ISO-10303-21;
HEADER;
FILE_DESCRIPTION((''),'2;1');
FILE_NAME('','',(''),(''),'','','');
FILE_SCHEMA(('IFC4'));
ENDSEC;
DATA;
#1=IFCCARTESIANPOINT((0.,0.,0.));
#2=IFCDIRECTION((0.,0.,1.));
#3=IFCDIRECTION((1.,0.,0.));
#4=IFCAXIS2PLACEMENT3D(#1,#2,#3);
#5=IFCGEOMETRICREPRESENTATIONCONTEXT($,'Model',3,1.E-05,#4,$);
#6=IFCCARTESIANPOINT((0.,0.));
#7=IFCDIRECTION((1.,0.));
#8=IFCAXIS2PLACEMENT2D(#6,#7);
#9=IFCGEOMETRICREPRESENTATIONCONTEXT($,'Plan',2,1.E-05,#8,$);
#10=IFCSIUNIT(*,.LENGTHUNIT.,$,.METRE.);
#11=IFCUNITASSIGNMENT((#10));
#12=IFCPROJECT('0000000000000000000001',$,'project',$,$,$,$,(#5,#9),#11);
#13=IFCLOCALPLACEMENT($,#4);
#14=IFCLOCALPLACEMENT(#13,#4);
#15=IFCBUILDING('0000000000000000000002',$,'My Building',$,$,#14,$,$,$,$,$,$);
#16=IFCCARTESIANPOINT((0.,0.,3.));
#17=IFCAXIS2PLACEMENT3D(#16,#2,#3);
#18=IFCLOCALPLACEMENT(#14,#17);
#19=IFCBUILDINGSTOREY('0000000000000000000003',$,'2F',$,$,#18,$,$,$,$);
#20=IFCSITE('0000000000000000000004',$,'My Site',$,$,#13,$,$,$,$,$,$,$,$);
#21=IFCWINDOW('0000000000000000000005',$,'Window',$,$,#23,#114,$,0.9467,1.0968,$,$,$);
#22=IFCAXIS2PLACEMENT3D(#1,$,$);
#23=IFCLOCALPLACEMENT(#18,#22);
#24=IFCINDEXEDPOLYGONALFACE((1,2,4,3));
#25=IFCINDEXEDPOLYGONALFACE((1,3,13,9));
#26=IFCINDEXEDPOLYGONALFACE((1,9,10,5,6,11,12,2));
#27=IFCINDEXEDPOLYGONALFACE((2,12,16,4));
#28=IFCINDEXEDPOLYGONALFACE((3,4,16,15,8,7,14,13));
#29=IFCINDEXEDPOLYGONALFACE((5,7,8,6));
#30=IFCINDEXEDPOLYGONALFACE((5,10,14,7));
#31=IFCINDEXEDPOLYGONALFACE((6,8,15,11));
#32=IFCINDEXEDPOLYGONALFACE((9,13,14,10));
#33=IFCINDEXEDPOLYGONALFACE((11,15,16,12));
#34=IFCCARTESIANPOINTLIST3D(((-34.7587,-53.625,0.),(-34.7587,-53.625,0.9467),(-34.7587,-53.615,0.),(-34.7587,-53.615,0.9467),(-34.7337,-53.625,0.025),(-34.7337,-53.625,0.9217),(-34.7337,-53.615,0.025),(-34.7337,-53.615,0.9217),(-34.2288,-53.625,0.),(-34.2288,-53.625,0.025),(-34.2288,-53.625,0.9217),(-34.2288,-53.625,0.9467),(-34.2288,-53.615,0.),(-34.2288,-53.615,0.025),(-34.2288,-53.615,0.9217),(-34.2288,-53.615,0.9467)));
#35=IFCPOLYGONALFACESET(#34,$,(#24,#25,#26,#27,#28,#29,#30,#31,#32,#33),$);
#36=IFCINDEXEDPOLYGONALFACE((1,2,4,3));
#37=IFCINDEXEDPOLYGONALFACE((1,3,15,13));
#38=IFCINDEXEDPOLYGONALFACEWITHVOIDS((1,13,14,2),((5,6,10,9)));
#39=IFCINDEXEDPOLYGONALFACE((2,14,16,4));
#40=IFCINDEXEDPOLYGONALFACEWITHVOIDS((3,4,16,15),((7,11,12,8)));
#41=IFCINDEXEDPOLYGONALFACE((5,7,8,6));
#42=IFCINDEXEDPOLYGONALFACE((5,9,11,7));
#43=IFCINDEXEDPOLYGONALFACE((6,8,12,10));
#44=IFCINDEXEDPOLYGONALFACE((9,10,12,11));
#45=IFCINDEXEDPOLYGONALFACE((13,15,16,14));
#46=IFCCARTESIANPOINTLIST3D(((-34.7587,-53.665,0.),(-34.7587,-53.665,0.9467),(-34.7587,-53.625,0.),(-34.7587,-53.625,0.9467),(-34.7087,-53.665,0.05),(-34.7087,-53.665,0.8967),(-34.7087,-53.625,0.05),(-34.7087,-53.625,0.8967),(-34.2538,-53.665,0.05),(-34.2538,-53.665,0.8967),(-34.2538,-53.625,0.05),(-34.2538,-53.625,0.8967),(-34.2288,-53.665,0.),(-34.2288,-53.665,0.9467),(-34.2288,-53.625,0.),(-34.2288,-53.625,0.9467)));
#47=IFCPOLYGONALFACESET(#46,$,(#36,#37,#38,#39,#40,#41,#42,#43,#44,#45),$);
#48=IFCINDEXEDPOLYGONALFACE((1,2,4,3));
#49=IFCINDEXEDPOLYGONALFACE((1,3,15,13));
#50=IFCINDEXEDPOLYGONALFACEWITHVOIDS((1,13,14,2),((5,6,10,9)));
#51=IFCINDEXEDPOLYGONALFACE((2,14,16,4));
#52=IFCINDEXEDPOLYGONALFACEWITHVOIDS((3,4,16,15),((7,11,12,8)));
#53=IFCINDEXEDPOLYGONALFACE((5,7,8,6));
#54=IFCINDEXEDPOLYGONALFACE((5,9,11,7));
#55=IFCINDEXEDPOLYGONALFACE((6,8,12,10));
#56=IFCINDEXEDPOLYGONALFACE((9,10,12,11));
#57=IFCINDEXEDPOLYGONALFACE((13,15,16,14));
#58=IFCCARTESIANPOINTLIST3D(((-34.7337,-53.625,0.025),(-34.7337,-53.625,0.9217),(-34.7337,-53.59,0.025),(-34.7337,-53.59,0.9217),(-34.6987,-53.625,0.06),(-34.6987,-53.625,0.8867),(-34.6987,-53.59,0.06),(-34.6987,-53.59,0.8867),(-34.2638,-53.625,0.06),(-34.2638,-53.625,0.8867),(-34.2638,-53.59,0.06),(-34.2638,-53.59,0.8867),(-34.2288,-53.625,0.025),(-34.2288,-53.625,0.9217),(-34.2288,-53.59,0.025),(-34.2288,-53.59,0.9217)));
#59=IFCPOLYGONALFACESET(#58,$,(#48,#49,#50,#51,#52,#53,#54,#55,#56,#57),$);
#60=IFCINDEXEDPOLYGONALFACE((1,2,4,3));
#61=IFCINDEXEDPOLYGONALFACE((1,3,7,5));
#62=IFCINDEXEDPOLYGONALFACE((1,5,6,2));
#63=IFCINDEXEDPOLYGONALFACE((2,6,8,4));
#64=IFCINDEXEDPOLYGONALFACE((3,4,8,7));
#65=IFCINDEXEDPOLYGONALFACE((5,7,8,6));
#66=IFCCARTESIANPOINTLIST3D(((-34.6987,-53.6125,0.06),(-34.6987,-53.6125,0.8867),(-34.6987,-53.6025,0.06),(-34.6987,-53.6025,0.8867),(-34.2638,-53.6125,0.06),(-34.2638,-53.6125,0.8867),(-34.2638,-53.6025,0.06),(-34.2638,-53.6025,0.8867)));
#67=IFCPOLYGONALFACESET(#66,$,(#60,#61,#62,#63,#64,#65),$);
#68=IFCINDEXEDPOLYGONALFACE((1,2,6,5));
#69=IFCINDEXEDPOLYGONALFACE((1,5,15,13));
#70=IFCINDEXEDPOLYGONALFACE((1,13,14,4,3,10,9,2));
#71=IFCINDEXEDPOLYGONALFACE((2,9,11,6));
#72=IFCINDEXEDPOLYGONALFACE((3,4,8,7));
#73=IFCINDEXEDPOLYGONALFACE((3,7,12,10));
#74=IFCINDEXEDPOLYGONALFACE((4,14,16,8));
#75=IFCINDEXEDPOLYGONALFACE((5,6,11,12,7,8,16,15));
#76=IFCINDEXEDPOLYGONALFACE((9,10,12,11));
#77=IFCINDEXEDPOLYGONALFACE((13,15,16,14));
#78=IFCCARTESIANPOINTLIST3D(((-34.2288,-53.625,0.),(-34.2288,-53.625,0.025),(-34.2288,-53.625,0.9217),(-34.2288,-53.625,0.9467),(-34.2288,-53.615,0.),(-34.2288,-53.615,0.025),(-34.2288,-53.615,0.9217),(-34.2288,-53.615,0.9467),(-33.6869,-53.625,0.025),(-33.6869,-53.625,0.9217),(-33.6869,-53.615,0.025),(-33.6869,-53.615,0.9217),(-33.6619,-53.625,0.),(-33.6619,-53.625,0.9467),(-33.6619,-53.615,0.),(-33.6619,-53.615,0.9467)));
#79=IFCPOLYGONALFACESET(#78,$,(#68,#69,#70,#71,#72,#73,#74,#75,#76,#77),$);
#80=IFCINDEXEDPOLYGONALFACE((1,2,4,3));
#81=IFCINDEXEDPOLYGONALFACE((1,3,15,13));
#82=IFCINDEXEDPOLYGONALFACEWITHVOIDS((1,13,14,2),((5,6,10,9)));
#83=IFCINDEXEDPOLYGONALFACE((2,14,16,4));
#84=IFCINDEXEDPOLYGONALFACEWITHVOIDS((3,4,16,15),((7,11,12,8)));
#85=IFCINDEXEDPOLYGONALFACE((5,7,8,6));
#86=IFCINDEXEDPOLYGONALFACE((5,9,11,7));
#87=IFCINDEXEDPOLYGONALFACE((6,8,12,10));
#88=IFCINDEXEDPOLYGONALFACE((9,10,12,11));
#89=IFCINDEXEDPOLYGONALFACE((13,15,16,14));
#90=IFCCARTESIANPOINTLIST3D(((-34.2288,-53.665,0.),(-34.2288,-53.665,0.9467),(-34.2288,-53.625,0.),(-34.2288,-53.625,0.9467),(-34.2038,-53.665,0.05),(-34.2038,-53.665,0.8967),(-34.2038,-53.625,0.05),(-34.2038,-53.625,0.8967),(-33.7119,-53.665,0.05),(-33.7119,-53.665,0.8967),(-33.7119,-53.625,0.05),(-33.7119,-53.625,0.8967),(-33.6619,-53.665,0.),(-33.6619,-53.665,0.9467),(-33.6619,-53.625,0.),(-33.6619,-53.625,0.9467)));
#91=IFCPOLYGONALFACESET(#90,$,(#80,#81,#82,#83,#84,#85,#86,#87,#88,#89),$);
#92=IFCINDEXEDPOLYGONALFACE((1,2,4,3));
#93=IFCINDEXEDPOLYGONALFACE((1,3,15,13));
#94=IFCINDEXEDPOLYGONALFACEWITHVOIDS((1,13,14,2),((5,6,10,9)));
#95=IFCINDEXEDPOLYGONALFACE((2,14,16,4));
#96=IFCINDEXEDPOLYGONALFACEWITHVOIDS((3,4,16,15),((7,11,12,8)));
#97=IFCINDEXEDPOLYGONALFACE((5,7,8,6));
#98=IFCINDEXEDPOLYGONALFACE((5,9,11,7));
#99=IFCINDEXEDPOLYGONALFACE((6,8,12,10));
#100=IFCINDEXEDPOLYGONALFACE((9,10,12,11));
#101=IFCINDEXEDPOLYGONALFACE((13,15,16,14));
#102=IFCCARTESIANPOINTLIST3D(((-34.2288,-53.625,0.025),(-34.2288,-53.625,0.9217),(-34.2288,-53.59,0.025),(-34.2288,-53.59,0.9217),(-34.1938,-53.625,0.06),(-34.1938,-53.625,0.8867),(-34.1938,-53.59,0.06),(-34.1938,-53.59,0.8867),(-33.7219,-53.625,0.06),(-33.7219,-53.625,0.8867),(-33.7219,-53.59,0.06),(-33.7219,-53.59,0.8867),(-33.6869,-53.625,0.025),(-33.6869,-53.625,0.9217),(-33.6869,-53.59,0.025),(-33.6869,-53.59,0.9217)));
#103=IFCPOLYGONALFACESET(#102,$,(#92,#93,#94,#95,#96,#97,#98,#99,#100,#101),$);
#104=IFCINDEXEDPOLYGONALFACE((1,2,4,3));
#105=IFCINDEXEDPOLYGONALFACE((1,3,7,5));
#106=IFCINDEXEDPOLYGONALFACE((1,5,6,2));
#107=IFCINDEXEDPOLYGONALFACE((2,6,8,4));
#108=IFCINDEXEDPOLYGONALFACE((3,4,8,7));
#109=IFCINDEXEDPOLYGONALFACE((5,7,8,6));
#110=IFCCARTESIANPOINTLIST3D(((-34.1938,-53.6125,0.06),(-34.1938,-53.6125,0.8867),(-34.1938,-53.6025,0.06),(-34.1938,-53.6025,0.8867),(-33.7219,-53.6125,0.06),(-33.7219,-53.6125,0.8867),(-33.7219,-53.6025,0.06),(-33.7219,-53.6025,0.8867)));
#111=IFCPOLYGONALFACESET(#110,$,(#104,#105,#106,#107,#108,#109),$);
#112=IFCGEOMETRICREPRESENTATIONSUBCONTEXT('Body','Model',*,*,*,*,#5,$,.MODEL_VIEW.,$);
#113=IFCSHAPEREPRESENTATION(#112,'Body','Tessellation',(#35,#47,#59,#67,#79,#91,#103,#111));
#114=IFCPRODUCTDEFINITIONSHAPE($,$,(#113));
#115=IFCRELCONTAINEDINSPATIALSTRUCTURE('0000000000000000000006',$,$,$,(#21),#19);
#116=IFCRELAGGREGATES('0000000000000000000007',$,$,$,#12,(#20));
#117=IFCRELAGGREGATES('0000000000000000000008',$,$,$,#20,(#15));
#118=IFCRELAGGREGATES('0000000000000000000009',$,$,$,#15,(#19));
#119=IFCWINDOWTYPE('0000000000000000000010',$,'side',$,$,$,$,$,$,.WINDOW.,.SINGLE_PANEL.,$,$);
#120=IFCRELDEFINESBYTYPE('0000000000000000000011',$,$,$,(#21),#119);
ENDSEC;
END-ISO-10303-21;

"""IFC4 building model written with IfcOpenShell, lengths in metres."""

from ifc_helpers import new_model, entity, si_unit, frame, origin_with_axes, origin_2d_with_axis, place, context, subcontext, project, spatial, line, indexed_curve, outline, extrude, shape, source, transform, mapped, type_object, type_shapes, element, save


model = new_model("IFC4")

# Units and contexts
model_context = context("Model", 3, precision=1e-05, world=origin_with_axes())
plan_context = context("Plan", 2, precision=1e-05, world=origin_2d_with_axis())
body_context_1 = subcontext(model_context, "Body", "Model", "MODEL_VIEW")
body_context_2 = subcontext(plan_context, "Body", "Plan", "PLAN_VIEW")
ifc_project = project(units=[si_unit("LENGTHUNIT", "METRE")], contexts=[model_context, plan_context])

# Site, building, storey
site_placement = place(None, origin_with_axes())
site = spatial("IfcSite", under=ifc_project, at=site_placement, Name="My Site")
building_placement = place(site_placement, origin_with_axes())
building = spatial("IfcBuilding", under=site, at=building_placement, Name="My Building")
storey_placement = place(building_placement, frame((0.0, 0.0, 3.0), z_axis=(0.0, 0.0, 1.0), x_axis=(1.0, 0.0, 0.0)))
storey = spatial("IfcBuildingStorey", under=building, at=storey_placement, Name="2F")

# Shared definitions
window_type_1 = type_object("IfcWindowType", Name="side", PartitioningType="SINGLE_PANEL", PredefinedType="WINDOW")
shared_shape_1 = source(origin_with_axes(), body_context_1, "Body", "SweptSolid", [
    extrude(outline(indexed_curve([(0.5299, 0.0), (0.0, 0.0), (0.0, 0.9467), (0.5299, 0.9467), (0.5299, 0.9217), (0.025, 0.9217), (0.025, 0.025), (0.5299, 0.025)], segments=[line(1, 2, 3, 4, 5, 6, 7, 8, 1)])), frame((0.0, 0.09, 0.0), z_axis=(0.0, -1.0, 0.0), x_axis=(1.0, 0.0, 0.0)), (0.0, 0.0, -1.0), 0.01),
    extrude(outline(indexed_curve([(0.0, 0.0), (0.5299, 0.0), (0.5299, 0.9467), (0.0, 0.9467)], segments=[line(1, 2, 3, 4, 1)]), holes=[indexed_curve([(0.05, 0.05), (0.5049, 0.05), (0.5049, 0.8967), (0.05, 0.8967)], segments=[line(1, 2, 3, 4, 1)])]), frame((0.0, 0.05, 0.0), z_axis=(0.0, -1.0, 0.0), x_axis=(1.0, 0.0, 0.0)), (0.0, 0.0, -1.0), 0.04),
    extrude(outline(indexed_curve([(0.0, 0.0), (0.5049, 0.0), (0.5049, 0.8967), (0.0, 0.8967)], segments=[line(1, 2, 3, 4, 1)]), holes=[indexed_curve([(0.035, 0.035), (0.4699, 0.035), (0.4699, 0.8617), (0.035, 0.8617)], segments=[line(1, 2, 3, 4, 1)])]), frame((0.025, 0.09, 0.025), z_axis=(0.0, -1.0, 0.0), x_axis=(1.0, 0.0, 0.0)), (0.0, 0.0, -1.0), 0.035),
    extrude(outline(indexed_curve([(0.035, 0.035), (0.4699, 0.035), (0.4699, 0.8617), (0.035, 0.8617)], segments=[line(1, 2, 3, 4, 1)])), frame((0.025, 0.1025, 0.025), z_axis=(0.0, -1.0, 0.0), x_axis=(1.0, 0.0, 0.0)), (0.0, 0.0, -1.0), 0.01),
    extrude(outline(indexed_curve([(0.0, 0.9467), (0.5669, 0.9467), (0.5669, 0.0), (0.0, 0.0), (0.0, 0.025), (0.5419, 0.025), (0.5419, 0.9217), (0.0, 0.9217)], segments=[line(1, 2, 3, 4, 5, 6, 7, 8, 1)])), frame((0.5299, 0.09, 0.0), z_axis=(0.0, -1.0, 0.0), x_axis=(1.0, 0.0, 0.0)), (0.0, 0.0, -1.0), 0.01),
    extrude(outline(indexed_curve([(0.0, 0.0), (0.5669, 0.0), (0.5669, 0.9467), (0.0, 0.9467)], segments=[line(1, 2, 3, 4, 1)]), holes=[indexed_curve([(0.025, 0.05), (0.5169, 0.05), (0.5169, 0.8967), (0.025, 0.8967)], segments=[line(1, 2, 3, 4, 1)])]), frame((0.5299, 0.05, 0.0), z_axis=(0.0, -1.0, 0.0), x_axis=(1.0, 0.0, 0.0)), (0.0, 0.0, -1.0), 0.04),
    extrude(outline(indexed_curve([(0.0, 0.0), (0.5419, 0.0), (0.5419, 0.8967), (0.0, 0.8967)], segments=[line(1, 2, 3, 4, 1)]), holes=[indexed_curve([(0.035, 0.035), (0.5069, 0.035), (0.5069, 0.8617), (0.035, 0.8617)], segments=[line(1, 2, 3, 4, 1)])]), frame((0.5299, 0.09, 0.025), z_axis=(0.0, -1.0, 0.0), x_axis=(1.0, 0.0, 0.0)), (0.0, 0.0, -1.0), 0.035),
    extrude(outline(indexed_curve([(0.035, 0.035), (0.5069, 0.035), (0.5069, 0.8617), (0.035, 0.8617)], segments=[line(1, 2, 3, 4, 1)])), frame((0.5299, 0.1025, 0.025), z_axis=(0.0, -1.0, 0.0), x_axis=(1.0, 0.0, 0.0)), (0.0, 0.0, -1.0), 0.01),
])
shared_shape_2 = source(origin_with_axes(), body_context_2, "Body", "Curve2D", [
    entity("IfcIndexedPolyCurve", entity("IfcCartesianPointList2D", [[0.05, 0.05], [0.5049, 0.05]])),
    entity("IfcIndexedPolyCurve", entity("IfcCartesianPointList2D", [[0.0, 0.1], [0.025, 0.1], [0.025, 0.09], [0.05, 0.09], [0.05, 0.05], [0.0, 0.05]]), [entity("IfcLineIndex", [1, 2, 3, 4, 5, 6, 1])]),
    entity("IfcIndexedPolyCurve", entity("IfcCartesianPointList2D", [[0.5299, 0.1], [0.5299, 0.1], [0.5299, 0.09], [0.5049, 0.09], [0.5049, 0.05], [0.5299, 0.05]])),
    entity("IfcIndexedPolyCurve", entity("IfcCartesianPointList2D", [[0.025, 0.09], [0.06, 0.09], [0.06, 0.125], [0.025, 0.125]]), [entity("IfcLineIndex", [1, 2, 3, 4, 1])]),
    entity("IfcIndexedPolyCurve", entity("IfcCartesianPointList2D", [[0.5299, 0.09], [0.4949, 0.09], [0.4949, 0.125], [0.5299, 0.125]]), [entity("IfcLineIndex", [1, 2, 3, 4, 1])]),
    entity("IfcIndexedPolyCurve", entity("IfcCartesianPointList2D", [[0.06, 0.09], [0.4949, 0.09]])),
    entity("IfcIndexedPolyCurve", entity("IfcCartesianPointList2D", [[0.06, 0.125], [0.4949, 0.125]])),
    entity("IfcIndexedPolyCurve", entity("IfcCartesianPointList2D", [[0.06, 0.1075], [0.4949, 0.1075]])),
    entity("IfcIndexedPolyCurve", entity("IfcCartesianPointList2D", [[0.5549, 0.05], [1.0468, 0.05]])),
    entity("IfcIndexedPolyCurve", entity("IfcCartesianPointList2D", [[0.5299, 0.1], [0.5299, 0.1], [0.5299, 0.09], [0.5549, 0.09], [0.5549, 0.05], [0.5299, 0.05]])),
    entity("IfcIndexedPolyCurve", entity("IfcCartesianPointList2D", [[1.0968, 0.1], [1.0718, 0.1], [1.0718, 0.09], [1.0468, 0.09], [1.0468, 0.05], [1.0968, 0.05]]), [entity("IfcLineIndex", [1, 2, 3, 4, 5, 6, 1])]),
    entity("IfcIndexedPolyCurve", entity("IfcCartesianPointList2D", [[0.5299, 0.09], [0.5649, 0.09], [0.5649, 0.125], [0.5299, 0.125]]), [entity("IfcLineIndex", [1, 2, 3, 4, 1])]),
    entity("IfcIndexedPolyCurve", entity("IfcCartesianPointList2D", [[1.0718, 0.09], [1.0368, 0.09], [1.0368, 0.125], [1.0718, 0.125]]), [entity("IfcLineIndex", [1, 2, 3, 4, 1])]),
    entity("IfcIndexedPolyCurve", entity("IfcCartesianPointList2D", [[0.5649, 0.09], [1.0368, 0.09]])),
    entity("IfcIndexedPolyCurve", entity("IfcCartesianPointList2D", [[0.5649, 0.125], [1.0368, 0.125]])),
    entity("IfcIndexedPolyCurve", entity("IfcCartesianPointList2D", [[0.5649, 0.1075], [1.0368, 0.1075]])),
])
type_shapes(window_type_1, [shared_shape_1, shared_shape_2])

# Window
window_1_placement = place(storey_placement, frame((-34.7587, -53.715, 0.0), z_axis=(0.0, 0.0, 1.0), x_axis=(1.0, 0.0, 0.0)))
element("IfcWindow", 1, at=window_1_placement, inside=storey, type_object=window_type_1, Name="Window", OverallHeight=0.9467, OverallWidth=1.0968, shapes=[
    shape(body_context_1, "Body", "MappedRepresentation", [mapped(shared_shape_1, transform((0.0, 0.0, 0.0), x_axis=(1.0, 0.0, 0.0), y_axis=(0.0, 1.0, 0.0), z_axis=(0.0, 0.0, 1.0), scale=1.0))]),
    shape(body_context_2, "Body", "MappedRepresentation", [mapped(shared_shape_2, transform((0.0, 0.0, 0.0), x_axis=(1.0, 0.0, 0.0), y_axis=(0.0, 1.0, 0.0), z_axis=(0.0, 0.0, 1.0), scale=1.0))]),
])

save(model, "model.ifc")
